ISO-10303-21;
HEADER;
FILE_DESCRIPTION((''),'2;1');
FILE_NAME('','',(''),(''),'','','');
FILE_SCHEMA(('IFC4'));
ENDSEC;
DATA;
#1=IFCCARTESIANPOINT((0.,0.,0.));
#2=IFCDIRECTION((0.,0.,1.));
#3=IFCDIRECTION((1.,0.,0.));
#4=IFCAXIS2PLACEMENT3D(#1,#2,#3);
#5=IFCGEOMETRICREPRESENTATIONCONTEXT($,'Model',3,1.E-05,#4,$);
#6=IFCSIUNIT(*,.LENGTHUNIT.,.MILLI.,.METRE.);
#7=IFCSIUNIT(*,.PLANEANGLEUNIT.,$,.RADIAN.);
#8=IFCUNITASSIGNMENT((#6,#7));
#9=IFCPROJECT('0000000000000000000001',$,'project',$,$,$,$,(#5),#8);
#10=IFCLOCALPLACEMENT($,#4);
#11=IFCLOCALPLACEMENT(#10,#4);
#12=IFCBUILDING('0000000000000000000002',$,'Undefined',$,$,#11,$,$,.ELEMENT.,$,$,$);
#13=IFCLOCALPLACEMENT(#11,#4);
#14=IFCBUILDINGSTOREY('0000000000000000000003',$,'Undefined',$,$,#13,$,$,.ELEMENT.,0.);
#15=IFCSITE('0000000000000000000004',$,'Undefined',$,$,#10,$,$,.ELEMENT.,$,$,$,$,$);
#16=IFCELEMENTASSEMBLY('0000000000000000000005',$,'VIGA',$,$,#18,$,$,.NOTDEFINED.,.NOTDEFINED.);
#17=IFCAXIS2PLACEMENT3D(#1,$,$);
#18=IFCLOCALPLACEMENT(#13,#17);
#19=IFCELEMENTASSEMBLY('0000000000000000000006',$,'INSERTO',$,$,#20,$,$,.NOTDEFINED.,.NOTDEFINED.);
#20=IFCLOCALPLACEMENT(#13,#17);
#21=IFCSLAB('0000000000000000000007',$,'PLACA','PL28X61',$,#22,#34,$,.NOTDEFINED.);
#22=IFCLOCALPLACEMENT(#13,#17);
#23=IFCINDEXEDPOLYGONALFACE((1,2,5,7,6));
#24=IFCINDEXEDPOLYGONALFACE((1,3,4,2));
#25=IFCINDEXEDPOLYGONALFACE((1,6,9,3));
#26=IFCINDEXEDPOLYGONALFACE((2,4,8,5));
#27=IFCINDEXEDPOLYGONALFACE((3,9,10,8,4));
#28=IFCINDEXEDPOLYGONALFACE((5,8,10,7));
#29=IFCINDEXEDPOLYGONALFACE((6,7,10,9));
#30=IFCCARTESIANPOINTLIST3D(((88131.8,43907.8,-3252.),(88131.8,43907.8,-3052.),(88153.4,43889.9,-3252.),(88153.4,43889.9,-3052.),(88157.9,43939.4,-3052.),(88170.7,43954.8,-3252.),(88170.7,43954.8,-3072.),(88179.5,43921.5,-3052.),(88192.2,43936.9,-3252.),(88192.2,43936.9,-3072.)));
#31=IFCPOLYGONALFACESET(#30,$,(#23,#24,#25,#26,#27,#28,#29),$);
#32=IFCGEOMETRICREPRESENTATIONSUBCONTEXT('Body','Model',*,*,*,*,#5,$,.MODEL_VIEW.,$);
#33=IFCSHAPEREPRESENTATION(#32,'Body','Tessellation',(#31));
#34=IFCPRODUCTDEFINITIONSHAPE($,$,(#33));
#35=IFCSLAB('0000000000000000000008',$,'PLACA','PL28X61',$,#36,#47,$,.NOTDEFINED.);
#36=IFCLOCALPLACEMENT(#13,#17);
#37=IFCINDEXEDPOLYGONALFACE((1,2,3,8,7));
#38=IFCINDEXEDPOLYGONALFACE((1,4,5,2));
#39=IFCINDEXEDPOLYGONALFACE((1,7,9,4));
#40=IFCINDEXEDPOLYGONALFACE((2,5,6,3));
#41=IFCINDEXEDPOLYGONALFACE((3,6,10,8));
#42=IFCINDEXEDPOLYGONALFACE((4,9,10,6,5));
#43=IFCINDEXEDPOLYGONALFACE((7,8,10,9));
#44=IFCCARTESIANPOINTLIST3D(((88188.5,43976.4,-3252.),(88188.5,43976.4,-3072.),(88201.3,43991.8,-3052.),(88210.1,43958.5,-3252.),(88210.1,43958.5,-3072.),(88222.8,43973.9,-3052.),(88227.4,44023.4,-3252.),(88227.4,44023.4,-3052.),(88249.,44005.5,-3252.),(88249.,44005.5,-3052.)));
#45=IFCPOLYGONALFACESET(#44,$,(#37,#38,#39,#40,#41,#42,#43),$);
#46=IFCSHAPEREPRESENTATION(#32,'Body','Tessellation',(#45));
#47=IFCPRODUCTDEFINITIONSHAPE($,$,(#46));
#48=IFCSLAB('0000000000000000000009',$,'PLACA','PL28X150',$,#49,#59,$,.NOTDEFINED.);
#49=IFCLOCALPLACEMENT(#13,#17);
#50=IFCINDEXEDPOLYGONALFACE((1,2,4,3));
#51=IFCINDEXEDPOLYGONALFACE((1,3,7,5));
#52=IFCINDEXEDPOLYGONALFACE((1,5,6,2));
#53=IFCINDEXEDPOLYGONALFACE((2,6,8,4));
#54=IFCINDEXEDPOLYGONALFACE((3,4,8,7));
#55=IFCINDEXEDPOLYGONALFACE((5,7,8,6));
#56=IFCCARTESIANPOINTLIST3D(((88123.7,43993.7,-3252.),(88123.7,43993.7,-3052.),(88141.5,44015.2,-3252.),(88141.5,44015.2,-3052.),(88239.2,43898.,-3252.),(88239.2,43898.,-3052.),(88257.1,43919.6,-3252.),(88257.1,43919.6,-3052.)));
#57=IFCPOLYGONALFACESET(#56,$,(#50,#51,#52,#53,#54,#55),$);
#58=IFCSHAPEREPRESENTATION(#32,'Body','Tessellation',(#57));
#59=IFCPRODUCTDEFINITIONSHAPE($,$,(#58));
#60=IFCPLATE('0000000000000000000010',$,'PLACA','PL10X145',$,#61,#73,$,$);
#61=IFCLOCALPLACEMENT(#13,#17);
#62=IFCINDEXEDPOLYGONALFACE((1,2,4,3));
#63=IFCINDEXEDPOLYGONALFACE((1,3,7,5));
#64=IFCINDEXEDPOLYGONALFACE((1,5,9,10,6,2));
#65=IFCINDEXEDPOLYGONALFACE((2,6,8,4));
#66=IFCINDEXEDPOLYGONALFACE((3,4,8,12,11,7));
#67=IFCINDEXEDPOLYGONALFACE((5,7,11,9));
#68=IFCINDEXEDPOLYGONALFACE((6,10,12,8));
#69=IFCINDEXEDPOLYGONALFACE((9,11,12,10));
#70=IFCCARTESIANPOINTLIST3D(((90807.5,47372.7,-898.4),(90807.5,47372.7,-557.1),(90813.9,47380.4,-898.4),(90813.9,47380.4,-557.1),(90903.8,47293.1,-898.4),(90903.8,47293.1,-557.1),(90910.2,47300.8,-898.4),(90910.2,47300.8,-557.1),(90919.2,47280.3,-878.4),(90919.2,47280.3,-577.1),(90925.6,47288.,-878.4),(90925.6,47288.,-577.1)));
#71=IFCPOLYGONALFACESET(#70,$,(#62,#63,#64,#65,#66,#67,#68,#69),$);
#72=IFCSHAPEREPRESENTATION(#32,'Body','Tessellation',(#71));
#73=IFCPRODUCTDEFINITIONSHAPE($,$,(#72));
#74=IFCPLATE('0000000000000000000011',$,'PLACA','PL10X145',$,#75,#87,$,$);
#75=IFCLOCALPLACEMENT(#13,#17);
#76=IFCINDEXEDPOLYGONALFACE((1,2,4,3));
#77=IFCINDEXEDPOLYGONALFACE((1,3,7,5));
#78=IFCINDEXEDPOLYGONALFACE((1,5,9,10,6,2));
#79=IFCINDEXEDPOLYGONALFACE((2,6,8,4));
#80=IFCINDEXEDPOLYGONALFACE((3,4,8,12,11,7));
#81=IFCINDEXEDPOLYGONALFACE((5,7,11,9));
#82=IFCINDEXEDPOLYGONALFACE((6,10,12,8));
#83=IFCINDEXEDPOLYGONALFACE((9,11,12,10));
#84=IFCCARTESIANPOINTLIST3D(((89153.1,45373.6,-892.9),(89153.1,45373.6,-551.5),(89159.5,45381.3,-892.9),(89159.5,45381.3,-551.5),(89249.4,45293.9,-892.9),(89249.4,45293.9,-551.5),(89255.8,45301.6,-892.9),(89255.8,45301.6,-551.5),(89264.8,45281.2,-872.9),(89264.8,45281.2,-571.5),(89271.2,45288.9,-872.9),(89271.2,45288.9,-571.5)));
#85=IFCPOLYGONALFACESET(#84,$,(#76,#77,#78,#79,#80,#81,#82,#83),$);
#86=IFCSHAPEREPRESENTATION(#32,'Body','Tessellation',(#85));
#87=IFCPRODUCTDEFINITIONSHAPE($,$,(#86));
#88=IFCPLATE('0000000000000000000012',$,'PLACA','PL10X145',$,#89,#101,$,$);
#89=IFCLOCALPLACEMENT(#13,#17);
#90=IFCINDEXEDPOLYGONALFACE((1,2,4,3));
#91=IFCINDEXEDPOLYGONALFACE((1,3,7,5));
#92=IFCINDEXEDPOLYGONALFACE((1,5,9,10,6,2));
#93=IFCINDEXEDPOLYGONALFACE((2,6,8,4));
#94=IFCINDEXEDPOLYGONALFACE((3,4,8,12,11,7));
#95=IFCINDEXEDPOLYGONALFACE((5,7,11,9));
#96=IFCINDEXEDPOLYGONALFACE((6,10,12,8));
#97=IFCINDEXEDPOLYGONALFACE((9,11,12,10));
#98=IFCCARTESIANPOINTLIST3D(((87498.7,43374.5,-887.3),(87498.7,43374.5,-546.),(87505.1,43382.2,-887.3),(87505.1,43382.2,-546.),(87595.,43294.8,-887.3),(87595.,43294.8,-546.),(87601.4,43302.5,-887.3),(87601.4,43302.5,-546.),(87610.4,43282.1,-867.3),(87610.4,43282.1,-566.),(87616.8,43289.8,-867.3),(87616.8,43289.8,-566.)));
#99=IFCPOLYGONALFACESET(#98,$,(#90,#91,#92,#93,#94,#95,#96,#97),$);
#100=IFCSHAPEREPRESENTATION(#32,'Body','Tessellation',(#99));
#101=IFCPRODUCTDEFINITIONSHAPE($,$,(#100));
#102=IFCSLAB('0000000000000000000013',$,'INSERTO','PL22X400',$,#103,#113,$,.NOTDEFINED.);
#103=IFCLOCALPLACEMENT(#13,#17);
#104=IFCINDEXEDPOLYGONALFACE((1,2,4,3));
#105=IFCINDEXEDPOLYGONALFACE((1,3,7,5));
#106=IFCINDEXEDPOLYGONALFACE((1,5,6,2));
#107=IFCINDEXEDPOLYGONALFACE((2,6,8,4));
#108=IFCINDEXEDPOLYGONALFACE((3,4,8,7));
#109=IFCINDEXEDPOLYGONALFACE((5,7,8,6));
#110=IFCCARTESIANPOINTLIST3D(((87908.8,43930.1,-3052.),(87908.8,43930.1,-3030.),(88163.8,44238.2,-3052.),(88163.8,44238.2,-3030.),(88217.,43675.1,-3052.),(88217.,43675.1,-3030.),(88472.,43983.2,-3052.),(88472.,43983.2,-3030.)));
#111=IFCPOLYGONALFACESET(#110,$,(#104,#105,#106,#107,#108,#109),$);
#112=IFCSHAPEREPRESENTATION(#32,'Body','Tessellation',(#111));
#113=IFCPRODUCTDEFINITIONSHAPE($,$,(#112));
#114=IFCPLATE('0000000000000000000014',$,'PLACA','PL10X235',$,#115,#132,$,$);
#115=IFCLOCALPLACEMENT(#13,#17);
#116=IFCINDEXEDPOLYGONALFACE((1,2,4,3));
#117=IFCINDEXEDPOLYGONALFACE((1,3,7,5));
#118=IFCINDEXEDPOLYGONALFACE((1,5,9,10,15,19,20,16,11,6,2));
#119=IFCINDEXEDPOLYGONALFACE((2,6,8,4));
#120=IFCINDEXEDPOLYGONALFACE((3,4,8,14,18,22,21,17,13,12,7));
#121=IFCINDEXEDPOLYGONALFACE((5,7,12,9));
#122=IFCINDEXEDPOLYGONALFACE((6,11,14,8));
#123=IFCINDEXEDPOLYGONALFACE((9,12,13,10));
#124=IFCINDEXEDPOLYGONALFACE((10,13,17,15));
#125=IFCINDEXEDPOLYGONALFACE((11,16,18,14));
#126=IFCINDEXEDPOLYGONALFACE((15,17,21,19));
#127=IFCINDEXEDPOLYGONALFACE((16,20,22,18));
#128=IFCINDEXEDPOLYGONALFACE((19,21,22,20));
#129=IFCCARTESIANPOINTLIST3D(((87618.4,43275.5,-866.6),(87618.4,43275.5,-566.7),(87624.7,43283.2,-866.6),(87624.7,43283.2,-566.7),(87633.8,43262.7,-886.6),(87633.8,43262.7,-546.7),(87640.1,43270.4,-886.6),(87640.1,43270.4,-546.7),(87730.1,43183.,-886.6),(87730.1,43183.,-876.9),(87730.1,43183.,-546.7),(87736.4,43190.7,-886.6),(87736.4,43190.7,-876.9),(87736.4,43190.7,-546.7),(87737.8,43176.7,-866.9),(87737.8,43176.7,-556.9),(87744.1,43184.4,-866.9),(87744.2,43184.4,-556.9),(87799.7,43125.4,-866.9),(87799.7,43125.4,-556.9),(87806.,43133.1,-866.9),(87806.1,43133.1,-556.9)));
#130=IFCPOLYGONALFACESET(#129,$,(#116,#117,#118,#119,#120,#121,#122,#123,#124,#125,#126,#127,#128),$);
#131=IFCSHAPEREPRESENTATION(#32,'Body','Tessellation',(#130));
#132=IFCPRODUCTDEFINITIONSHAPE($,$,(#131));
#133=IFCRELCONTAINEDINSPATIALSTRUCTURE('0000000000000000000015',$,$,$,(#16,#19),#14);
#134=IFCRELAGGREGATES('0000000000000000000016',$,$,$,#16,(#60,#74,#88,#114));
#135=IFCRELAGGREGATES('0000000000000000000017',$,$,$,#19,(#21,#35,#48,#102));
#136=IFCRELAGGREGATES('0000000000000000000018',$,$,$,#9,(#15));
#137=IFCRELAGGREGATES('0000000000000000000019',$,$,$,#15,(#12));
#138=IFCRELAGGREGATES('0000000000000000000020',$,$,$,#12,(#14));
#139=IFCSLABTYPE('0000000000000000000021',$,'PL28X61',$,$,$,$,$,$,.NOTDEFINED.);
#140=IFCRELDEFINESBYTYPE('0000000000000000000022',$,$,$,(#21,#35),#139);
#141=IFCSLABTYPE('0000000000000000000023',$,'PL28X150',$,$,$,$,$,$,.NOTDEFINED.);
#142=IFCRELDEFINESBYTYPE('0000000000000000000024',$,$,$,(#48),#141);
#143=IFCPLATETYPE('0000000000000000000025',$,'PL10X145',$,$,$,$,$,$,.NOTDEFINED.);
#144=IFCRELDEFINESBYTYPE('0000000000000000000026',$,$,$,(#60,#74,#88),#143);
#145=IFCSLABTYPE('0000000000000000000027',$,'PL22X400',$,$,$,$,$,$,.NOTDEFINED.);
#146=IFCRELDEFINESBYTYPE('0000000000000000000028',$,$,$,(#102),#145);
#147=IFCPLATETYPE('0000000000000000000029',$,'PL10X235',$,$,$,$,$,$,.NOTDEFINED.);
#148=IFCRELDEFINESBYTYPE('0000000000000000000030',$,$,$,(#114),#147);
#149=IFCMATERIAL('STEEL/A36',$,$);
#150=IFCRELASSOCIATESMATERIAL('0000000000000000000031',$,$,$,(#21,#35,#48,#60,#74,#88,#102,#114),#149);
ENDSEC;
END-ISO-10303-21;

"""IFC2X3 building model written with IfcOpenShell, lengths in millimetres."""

from ifc_helpers import new_model, si_unit, frame, origin_with_axes, place, context, subcontext, project, spatial, polyline, outline, extrude, material, type_object, element, aggregate, save


model = new_model("IFC2X3")

# Units and contexts
model_context = context("Model", 3, precision=1e-05, world=origin_with_axes())
body_context = subcontext(model_context, "Body", "Model", "MODEL_VIEW")
ifc_project = project(units=[si_unit("LENGTHUNIT", "METRE", prefix="MILLI"), si_unit("PLANEANGLEUNIT", "RADIAN")], contexts=[model_context])

# Site, building, storey
site_placement = place(None, origin_with_axes())
site = spatial("IfcSite", under=ifc_project, at=site_placement, Name="Undefined", CompositionType="ELEMENT")
building_placement = place(site_placement, origin_with_axes())
building = spatial("IfcBuilding", under=site, at=building_placement, Name="Undefined", CompositionType="ELEMENT")
storey_placement = place(building_placement, origin_with_axes())
storey = spatial("IfcBuildingStorey", under=building, at=storey_placement, Name="Undefined", CompositionType="ELEMENT", Elevation=0.0)

# Shared definitions
ifc_material_1 = material(Name="STEEL/A36")

# Element assembly
assembly_1_placement = place(storey_placement, origin_with_axes())
assembly_1 = element("IfcElementAssembly", 1, at=assembly_1_placement, inside=storey, Name="VIGA", AssemblyPlace="NOTDEFINED", PredefinedType="NOTDEFINED")

# Element assembly, slabs
assembly_2_placement = place(storey_placement, origin_with_axes())
assembly_2 = element("IfcElementAssembly", 2, at=assembly_2_placement, inside=storey, Name="INSERTO", AssemblyPlace="NOTDEFINED", PredefinedType="NOTDEFINED")
slab_type_1 = type_object("IfcSlabType", Name="PL28X61", PredefinedType="NOTDEFINED")
slab_1_placement = place(assembly_2_placement, frame((88142.6, 43898.9, -3052.0), z_axis=(-0.770402, 0.637558, 0.0), x_axis=(0.637559, 0.770402, 0.0)))
slab_1 = element("IfcSlab", 3, at=slab_1_placement, type_object=slab_type_1, material=ifc_material_1, Name="PLACA", Description="PL28X61", PredefinedType="NOTDEFINED", context=body_context, shape_type="SweptSolid", body=[
    extrude(outline(polyline([(0.0, 0.0), (41.0, 0.0), (61.0, 20.0), (61.0, 200.0), (0.0, 200.0), (0.0, 0.0)])), frame((0.0, 0.0, -14.0), z_axis=(0.0, 0.0, 1.0), x_axis=(1.0, 0.0, 0.0)), (0.0, 0.0, 1.0), 28.0),
])
slab_2_placement = place(assembly_2_placement, frame((88199.3, 43967.4, -3052.0), z_axis=(-0.770402, 0.637558, 0.0), x_axis=(0.637559, 0.770402, 0.0)))
slab_2 = element("IfcSlab", 4, at=slab_2_placement, type_object=slab_type_1, material=ifc_material_1, Name="PLACA", Description="PL28X61", PredefinedType="NOTDEFINED", context=body_context, shape_type="SweptSolid", body=[
    extrude(outline(polyline([(0.0, 20.0), (20.0, 0.0), (61.0, 0.0), (61.0, 200.0), (0.0, 200.0), (0.0, 20.0)])), frame((0.0, 0.0, -14.0), z_axis=(0.0, 0.0, 1.0), x_axis=(1.0, 0.0, 0.0)), (0.0, 0.0, 1.0), 28.0),
])
slab_type_2 = type_object("IfcSlabType", Name="PL28X150", PredefinedType="NOTDEFINED")
slab_3_placement = place(assembly_2_placement, frame((88132.6, 44004.5, -3052.0), z_axis=(0.637559, 0.770402, 0.0), x_axis=(0.770402, -0.637558, 0.0)))
slab_3 = element("IfcSlab", 5, at=slab_3_placement, type_object=slab_type_2, material=ifc_material_1, Name="PLACA", Description="PL28X150", PredefinedType="NOTDEFINED", context=body_context, shape_type="SweptSolid", body=[
    extrude(outline(polyline([(0.0, 0.0), (150.0, 0.0), (150.0, 200.0), (0.0, 200.0), (0.0, 0.0)])), frame((0.0, 0.0, -14.0), z_axis=(0.0, 0.0, 1.0), x_axis=(1.0, 0.0, 0.0)), (0.0, 0.0, 1.0), 28.0),
])

# Plates
plate_type_1 = type_object("IfcPlateType", Name="PL10X145", PredefinedType="NOTDEFINED")
plate_1_placement = place(assembly_1_placement, frame((90922.4, 47284.2, -898.4), z_axis=(0.63756, 0.770401, 0.0), x_axis=(-0.770401, 0.63756, 0.0)))
plate_1 = element("IfcPlate", 6, at=plate_1_placement, type_object=plate_type_1, material=ifc_material_1, Name="PLACA", Description="PL10X145", context=body_context, shape_type="SweptSolid", body=[
    extrude(outline(polyline([(0.0, 20.0), (20.0, 0.0), (145.0, 0.0), (145.0, 341.4), (20.0, 341.4), (0.0, 321.4), (0.0, 20.0)])), frame((0.0, 0.0, -5.0), z_axis=(0.0, 0.0, 1.0), x_axis=(1.0, 0.0, 0.0)), (0.0, 0.0, 1.0), 10.0),
])
plate_2_placement = place(assembly_1_placement, frame((89268.0, 45285.0, -892.9), z_axis=(0.63756, 0.770401, 0.0), x_axis=(-0.770401, 0.63756, 0.0)))
plate_2 = element("IfcPlate", 7, at=plate_2_placement, type_object=plate_type_1, material=ifc_material_1, Name="PLACA", Description="PL10X145", context=body_context, shape_type="SweptSolid", body=[
    extrude(outline(polyline([(0.0, 20.0), (20.0, 0.0), (145.0, 0.0), (145.0, 341.4), (20.0, 341.4), (0.0, 321.4), (0.0, 20.0)])), frame((0.0, 0.0, -5.0), z_axis=(0.0, 0.0, 1.0), x_axis=(1.0, 0.0, 0.0)), (0.0, 0.0, 1.0), 10.0),
])
plate_3_placement = place(assembly_1_placement, frame((87613.6, 43285.9, -887.3), z_axis=(0.63756, 0.770401, 0.0), x_axis=(-0.770401, 0.63756, 0.0)))
plate_3 = element("IfcPlate", 8, at=plate_3_placement, type_object=plate_type_1, material=ifc_material_1, Name="PLACA", Description="PL10X145", context=body_context, shape_type="SweptSolid", body=[
    extrude(outline(polyline([(0.0, 20.0), (20.0, 0.0), (145.0, 0.0), (145.0, 341.4), (20.0, 341.4), (0.0, 321.4), (0.0, 20.0)])), frame((0.0, 0.0, -5.0), z_axis=(0.0, 0.0, 1.0), x_axis=(1.0, 0.0, 0.0)), (0.0, 0.0, 1.0), 10.0),
])

# Slab
slab_type_3 = type_object("IfcSlabType", Name="PL22X400", PredefinedType="NOTDEFINED")
slab_4_placement = place(assembly_2_placement, frame((87908.8, 43930.1, -3041.0), z_axis=(0.0, 0.0, 1.0), x_axis=(0.770402, -0.637558, 0.0)))
slab_4 = element("IfcSlab", 9, at=slab_4_placement, type_object=slab_type_3, material=ifc_material_1, Name="INSERTO", Description="PL22X400", PredefinedType="NOTDEFINED", context=body_context, shape_type="SweptSolid", body=[
    extrude(outline(polyline([(0.0, 0.0), (400.0, 0.0), (400.0, 400.0), (0.0, 400.0), (0.0, 0.0)])), frame((0.0, 0.0, -11.0), z_axis=(0.0, 0.0, 1.0), x_axis=(1.0, 0.0, 0.0)), (0.0, 0.0, 1.0), 22.0),
])

# Plate
plate_type_2 = type_object("IfcPlateType", Name="PL10X235", PredefinedType="NOTDEFINED")
plate_4_placement = place(assembly_1_placement, frame((87621.5, 43279.3, -866.6), z_axis=(-0.63756, -0.770401, 0.0), x_axis=(0.544756, -0.450823, -0.707107)))
plate_4 = element("IfcPlate", 10, at=plate_4_placement, type_object=plate_type_2, material=ifc_material_1, Name="PLACA", Description="PL10X235", context=body_context, shape_type="SweptSolid", body=[
    extrude(outline(polyline([(0.0, 0.0), (28.3, 0.0), (116.7, 88.4), (109.8, 95.3), (109.8, 109.4), (166.6, 166.3), (-52.6, 385.5), (-109.4, 328.6), (-123.7, 328.8), (-212.1, 240.4), (-212.1, 212.1), (0.0, 0.0)])), frame((0.0, 0.0, -5.0), z_axis=(0.0, 0.0, 1.0), x_axis=(1.0, 0.0, 0.0)), (0.0, 0.0, 1.0), 10.0),
])
aggregate(assembly_1, [plate_1, plate_2, plate_3, plate_4])

aggregate(assembly_2, [slab_1, slab_2, slab_3, slab_4])

save(model, "model.ifc")
